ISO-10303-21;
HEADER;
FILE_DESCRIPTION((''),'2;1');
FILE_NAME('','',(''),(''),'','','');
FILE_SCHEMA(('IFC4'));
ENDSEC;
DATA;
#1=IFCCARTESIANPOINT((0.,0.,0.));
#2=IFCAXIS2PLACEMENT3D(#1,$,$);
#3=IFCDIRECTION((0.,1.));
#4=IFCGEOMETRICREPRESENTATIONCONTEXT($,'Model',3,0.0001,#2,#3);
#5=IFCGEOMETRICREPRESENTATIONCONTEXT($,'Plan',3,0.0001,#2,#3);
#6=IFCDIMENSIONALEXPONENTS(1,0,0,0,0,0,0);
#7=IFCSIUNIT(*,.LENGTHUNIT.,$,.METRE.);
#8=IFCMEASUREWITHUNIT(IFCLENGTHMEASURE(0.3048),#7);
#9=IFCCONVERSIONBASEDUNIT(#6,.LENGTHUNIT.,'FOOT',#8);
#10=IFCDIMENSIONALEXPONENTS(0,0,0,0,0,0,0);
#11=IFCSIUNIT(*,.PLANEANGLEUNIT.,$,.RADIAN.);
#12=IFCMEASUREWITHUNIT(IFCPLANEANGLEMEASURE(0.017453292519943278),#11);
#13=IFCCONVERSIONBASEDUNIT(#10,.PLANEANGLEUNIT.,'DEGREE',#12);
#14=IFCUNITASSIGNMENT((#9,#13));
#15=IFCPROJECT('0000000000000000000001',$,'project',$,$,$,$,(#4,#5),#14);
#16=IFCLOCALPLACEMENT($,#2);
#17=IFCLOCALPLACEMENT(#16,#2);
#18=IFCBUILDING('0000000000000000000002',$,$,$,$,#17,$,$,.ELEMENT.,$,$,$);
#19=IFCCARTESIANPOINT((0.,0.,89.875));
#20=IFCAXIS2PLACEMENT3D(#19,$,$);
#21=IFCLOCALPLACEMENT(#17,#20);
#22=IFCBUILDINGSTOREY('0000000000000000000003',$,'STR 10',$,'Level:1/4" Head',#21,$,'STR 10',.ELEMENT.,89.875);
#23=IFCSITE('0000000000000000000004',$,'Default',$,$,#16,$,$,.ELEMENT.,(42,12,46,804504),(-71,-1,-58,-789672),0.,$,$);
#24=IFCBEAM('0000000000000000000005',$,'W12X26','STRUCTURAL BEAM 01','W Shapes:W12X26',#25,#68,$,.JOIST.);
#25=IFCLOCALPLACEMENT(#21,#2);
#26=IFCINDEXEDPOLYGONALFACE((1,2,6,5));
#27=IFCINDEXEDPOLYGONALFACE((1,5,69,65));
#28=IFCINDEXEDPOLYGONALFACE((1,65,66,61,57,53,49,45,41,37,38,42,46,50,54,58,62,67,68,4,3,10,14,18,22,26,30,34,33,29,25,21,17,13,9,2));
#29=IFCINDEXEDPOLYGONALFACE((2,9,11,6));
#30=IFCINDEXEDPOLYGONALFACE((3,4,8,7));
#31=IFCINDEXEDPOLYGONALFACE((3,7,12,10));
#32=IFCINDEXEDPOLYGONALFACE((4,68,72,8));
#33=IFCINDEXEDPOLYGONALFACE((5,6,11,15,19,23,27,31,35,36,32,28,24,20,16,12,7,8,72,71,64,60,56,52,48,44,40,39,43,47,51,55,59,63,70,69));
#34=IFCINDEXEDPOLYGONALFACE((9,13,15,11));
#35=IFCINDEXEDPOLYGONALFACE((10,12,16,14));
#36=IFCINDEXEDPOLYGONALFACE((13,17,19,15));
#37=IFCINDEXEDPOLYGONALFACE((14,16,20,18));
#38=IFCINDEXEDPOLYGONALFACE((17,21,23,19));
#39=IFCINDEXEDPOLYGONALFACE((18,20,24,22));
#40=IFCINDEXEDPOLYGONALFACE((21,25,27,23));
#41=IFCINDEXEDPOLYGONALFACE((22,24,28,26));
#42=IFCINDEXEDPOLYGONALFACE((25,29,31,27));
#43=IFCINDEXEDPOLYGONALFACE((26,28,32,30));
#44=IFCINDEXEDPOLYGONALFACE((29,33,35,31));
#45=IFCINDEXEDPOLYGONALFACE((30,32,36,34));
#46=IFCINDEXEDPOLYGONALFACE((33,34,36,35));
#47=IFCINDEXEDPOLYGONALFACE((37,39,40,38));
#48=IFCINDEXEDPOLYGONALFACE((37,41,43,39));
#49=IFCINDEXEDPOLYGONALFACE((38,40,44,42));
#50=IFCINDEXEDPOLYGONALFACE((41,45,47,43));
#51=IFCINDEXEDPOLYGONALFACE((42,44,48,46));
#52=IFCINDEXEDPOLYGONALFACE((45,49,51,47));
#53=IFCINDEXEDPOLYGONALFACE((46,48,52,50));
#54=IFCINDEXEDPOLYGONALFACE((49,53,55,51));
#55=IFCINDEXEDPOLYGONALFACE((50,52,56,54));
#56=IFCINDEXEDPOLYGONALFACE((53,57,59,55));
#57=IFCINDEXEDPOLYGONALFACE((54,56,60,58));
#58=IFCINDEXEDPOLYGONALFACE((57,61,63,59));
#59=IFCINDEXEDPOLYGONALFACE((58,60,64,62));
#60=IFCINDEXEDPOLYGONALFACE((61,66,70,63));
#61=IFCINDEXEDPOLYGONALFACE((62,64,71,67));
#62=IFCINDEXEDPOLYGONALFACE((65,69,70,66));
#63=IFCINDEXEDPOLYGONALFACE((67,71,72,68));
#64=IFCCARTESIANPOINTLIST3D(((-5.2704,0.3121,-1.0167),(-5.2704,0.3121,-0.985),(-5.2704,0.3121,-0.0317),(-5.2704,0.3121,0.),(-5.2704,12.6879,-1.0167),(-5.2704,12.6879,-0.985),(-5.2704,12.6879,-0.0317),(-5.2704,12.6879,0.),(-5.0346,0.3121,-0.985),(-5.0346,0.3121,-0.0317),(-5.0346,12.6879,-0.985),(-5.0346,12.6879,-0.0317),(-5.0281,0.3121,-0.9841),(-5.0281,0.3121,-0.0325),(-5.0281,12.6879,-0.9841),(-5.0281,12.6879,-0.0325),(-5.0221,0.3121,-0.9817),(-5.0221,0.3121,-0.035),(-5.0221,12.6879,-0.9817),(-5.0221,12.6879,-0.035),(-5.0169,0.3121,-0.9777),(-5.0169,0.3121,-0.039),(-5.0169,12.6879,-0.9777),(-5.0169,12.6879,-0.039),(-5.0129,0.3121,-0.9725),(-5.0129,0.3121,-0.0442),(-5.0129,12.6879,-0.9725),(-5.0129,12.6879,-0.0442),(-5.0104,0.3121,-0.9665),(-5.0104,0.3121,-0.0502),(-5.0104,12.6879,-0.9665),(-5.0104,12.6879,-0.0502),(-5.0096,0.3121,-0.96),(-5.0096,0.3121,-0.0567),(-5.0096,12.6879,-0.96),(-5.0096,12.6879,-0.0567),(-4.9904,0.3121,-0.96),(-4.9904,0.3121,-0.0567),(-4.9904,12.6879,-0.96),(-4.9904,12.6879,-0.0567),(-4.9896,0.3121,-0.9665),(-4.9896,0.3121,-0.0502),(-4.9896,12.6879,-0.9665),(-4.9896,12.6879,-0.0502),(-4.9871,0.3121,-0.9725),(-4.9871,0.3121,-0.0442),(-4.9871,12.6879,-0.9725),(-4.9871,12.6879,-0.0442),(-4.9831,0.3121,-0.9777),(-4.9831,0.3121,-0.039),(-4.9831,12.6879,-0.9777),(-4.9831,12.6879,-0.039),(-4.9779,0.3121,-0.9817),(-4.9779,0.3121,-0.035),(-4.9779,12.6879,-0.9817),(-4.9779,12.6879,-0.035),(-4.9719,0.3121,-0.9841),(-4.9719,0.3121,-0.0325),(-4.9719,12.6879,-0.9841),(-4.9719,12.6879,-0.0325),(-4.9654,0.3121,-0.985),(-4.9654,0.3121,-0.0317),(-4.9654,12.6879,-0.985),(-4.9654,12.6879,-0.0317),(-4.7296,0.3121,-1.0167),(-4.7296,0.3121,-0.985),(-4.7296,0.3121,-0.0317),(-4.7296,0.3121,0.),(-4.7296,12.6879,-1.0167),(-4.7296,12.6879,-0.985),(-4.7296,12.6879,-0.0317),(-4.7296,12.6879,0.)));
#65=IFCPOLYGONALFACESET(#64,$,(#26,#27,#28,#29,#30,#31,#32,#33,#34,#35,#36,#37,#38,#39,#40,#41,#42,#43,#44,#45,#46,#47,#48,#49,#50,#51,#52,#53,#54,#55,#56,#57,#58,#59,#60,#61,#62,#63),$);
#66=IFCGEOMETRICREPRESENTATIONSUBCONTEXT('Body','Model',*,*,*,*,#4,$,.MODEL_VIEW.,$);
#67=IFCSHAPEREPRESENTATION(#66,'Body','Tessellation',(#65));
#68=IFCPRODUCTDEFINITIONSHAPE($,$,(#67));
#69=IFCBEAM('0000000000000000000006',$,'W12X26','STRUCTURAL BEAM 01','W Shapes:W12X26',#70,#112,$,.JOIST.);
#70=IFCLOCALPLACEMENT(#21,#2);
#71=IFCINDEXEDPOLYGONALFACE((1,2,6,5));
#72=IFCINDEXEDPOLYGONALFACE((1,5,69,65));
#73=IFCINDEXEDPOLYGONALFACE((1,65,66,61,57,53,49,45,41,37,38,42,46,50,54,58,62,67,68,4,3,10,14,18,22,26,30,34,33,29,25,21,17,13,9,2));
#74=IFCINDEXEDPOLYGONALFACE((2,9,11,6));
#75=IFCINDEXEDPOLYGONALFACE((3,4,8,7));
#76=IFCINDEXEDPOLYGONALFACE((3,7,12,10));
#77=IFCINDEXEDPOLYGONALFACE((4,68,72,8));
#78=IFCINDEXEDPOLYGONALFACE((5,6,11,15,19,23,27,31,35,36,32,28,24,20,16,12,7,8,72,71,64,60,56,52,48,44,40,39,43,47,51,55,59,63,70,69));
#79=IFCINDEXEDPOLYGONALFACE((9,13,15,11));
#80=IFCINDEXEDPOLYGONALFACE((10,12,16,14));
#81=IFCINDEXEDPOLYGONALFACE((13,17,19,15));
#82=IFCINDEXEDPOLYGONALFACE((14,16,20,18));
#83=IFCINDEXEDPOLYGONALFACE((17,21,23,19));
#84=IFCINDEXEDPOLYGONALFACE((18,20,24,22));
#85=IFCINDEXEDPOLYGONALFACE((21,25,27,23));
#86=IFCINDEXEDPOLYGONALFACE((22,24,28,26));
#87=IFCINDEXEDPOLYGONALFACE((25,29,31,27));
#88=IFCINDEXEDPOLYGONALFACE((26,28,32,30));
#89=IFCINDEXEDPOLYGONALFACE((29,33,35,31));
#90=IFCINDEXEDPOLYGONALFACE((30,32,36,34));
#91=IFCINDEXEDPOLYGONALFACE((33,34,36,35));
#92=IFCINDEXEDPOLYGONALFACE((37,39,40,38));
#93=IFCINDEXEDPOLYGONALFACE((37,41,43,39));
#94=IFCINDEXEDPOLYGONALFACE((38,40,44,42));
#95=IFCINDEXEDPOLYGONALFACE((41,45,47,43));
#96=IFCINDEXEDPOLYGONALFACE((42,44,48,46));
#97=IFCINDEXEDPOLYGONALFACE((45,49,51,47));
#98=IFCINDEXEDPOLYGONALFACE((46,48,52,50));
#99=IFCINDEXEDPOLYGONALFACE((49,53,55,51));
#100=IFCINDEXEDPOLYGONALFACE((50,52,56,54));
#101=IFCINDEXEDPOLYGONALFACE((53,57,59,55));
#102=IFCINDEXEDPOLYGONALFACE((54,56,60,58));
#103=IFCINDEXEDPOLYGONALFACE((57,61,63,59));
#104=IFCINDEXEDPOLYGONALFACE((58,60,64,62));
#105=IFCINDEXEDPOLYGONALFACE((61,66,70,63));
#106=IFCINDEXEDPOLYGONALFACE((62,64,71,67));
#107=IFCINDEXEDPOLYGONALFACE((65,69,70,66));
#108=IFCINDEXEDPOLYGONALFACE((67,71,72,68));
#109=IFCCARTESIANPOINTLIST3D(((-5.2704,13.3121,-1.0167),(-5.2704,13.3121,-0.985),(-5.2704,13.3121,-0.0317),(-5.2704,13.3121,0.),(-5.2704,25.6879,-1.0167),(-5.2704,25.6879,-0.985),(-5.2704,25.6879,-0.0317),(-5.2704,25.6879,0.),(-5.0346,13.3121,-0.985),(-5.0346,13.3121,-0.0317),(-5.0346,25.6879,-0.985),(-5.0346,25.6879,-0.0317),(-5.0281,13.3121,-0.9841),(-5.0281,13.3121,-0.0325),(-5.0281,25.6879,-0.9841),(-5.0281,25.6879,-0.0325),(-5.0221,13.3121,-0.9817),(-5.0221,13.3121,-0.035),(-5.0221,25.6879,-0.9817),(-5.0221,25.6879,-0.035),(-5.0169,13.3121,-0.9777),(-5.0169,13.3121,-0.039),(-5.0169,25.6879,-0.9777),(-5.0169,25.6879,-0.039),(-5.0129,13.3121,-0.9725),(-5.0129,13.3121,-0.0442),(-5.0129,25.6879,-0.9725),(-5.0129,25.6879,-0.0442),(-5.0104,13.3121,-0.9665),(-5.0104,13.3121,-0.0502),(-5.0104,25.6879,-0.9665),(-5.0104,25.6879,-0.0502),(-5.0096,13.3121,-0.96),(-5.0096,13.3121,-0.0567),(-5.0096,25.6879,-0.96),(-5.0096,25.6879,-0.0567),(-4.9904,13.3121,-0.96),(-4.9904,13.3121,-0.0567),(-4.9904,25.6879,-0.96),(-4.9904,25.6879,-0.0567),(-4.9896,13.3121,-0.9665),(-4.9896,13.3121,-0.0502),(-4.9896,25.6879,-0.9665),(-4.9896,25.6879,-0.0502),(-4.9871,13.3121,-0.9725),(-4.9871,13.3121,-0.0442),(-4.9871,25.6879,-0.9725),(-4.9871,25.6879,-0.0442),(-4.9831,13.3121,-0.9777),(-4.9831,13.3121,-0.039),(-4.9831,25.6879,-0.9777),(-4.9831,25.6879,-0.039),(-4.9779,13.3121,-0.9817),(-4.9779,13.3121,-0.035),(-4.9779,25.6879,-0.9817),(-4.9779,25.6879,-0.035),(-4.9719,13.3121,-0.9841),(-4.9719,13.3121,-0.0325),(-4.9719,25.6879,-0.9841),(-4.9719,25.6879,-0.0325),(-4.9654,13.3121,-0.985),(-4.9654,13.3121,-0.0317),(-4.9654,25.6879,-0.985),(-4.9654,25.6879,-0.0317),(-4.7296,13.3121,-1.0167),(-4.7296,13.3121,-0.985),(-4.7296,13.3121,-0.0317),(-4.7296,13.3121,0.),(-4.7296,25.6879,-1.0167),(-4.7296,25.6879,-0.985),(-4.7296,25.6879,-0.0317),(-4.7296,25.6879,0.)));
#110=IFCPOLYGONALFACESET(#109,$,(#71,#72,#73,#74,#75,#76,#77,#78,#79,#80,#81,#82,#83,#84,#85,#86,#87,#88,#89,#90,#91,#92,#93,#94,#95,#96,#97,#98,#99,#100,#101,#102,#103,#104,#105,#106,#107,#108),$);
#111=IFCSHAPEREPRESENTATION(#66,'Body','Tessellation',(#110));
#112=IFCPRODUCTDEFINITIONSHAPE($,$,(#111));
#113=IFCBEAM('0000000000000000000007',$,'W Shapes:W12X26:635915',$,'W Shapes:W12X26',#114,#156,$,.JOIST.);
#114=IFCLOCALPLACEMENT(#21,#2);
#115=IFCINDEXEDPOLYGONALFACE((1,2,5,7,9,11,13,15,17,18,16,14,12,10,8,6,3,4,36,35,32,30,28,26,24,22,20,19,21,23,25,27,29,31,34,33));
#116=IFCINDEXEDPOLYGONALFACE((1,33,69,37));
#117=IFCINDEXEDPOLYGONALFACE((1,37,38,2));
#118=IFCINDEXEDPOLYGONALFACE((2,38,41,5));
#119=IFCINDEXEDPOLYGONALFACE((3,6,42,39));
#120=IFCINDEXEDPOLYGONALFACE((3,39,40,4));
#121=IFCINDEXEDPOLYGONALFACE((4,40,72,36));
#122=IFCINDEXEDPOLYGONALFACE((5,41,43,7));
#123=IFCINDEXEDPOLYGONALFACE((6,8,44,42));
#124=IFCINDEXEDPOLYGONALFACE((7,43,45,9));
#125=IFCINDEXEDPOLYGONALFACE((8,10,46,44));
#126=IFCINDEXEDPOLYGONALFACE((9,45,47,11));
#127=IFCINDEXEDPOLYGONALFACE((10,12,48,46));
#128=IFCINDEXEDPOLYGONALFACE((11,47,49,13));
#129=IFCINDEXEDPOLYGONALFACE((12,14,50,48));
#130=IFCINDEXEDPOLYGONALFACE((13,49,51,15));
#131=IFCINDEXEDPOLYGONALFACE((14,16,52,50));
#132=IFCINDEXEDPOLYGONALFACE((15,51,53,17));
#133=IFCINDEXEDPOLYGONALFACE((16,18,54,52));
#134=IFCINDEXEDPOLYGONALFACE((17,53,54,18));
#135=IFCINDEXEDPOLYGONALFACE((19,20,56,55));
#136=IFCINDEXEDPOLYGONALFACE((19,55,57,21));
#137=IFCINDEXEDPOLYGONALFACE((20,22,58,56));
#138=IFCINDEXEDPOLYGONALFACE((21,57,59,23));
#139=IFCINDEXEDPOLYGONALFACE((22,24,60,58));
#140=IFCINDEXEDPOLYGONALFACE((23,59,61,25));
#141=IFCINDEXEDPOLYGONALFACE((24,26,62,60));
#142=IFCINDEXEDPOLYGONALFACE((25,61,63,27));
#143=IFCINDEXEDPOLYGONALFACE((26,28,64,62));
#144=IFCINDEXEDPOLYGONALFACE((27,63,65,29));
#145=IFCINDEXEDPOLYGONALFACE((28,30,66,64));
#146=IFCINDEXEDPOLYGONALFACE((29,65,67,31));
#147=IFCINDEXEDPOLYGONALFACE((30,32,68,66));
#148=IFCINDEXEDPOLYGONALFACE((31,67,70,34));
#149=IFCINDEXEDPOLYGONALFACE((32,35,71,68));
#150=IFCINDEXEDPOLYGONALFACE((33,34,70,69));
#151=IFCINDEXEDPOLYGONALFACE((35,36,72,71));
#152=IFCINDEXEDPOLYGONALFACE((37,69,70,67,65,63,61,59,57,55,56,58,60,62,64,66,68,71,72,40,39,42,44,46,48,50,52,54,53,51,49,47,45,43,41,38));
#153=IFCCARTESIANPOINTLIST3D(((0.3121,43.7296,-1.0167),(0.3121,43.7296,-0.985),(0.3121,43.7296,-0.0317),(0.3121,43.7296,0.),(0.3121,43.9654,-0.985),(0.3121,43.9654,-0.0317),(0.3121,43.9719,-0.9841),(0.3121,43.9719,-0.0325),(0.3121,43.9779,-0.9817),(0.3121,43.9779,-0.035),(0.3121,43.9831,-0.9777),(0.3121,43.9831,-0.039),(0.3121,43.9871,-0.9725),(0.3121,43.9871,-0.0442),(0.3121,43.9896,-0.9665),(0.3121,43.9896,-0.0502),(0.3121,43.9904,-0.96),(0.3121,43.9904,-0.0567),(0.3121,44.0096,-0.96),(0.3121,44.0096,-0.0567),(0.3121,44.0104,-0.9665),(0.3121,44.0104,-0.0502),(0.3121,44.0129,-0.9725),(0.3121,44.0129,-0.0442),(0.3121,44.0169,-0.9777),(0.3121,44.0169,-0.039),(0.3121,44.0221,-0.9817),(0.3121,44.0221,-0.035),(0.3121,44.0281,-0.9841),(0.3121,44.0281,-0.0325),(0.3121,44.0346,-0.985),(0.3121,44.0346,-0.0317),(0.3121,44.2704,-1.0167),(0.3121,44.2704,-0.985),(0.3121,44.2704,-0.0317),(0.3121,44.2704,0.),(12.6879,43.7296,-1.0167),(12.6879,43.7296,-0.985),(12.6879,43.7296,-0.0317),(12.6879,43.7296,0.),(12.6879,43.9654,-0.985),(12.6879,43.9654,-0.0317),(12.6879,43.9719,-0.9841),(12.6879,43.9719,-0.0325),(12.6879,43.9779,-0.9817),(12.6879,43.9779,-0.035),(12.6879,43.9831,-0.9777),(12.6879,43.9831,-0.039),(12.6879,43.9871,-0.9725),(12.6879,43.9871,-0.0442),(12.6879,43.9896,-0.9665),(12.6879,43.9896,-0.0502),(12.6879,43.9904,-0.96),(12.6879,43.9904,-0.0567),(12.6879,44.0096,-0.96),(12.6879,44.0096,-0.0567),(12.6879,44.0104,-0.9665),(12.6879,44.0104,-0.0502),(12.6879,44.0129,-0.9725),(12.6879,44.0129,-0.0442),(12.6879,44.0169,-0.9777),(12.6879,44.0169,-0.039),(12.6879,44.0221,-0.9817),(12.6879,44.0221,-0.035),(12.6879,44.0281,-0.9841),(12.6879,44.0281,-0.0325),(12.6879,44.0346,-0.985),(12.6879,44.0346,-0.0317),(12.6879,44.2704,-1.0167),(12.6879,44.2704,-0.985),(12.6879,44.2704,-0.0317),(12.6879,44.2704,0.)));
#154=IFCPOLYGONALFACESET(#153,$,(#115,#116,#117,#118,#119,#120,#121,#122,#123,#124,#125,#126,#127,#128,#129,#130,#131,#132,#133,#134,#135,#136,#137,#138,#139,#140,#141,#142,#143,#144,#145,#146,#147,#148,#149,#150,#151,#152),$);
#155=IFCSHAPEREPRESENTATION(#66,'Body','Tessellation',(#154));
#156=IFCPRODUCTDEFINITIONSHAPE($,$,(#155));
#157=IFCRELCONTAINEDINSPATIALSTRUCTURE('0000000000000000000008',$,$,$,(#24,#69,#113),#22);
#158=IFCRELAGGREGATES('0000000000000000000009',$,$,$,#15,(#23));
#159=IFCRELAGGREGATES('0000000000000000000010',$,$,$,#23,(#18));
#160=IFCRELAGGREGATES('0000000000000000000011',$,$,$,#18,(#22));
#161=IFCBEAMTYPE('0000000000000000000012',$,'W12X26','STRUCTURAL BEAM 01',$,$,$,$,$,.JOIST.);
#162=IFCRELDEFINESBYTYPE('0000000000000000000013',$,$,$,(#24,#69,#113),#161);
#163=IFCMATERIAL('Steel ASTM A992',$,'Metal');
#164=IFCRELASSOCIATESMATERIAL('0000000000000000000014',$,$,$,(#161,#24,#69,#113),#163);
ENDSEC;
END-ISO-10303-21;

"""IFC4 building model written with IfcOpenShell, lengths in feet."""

from ifc_helpers import new_model, entity, si_unit, converted_unit, direction, frame, origin, place, context, subcontext, project, spatial, line, arc, indexed_curve, outline, extrude, source, transform, mapped, material, type_object, type_shapes, element, save


model = new_model("IFC4")

# Units and contexts
model_context = context("Model", 3, precision=0.0001, world=origin(), true_north=direction((0.0, 1.0)))
plan_context = context("Plan", 3, precision=0.0001, world=origin(), true_north=direction((0.0, 1.0)))
body_context = subcontext(model_context, "Body", "Model", "MODEL_VIEW")
ifc_project = project(units=[converted_unit("LENGTHUNIT", "FOOT", entity("IfcLengthMeasure", 0.3048), si_unit("LENGTHUNIT", "METRE"), dimensions=[1, 0, 0, 0, 0, 0, 0]), converted_unit("PLANEANGLEUNIT", "DEGREE", entity("IfcPlaneAngleMeasure", 0.017453292519943278), si_unit("PLANEANGLEUNIT", "RADIAN"), dimensions=[0, 0, 0, 0, 0, 0, 0])], contexts=[model_context, plan_context])

# Site, building, storey
site_placement = place(None, origin())
site = spatial("IfcSite", under=ifc_project, at=site_placement, Name="Default", CompositionType="ELEMENT", RefLatitude=(42, 12, 46, 804504), RefLongitude=(-71, -1, -58, -789672), RefElevation=0.0)
building_placement = place(site_placement, origin())
building = spatial("IfcBuilding", under=site, at=building_placement, CompositionType="ELEMENT")
storey_placement = place(building_placement, frame((0.0, 0.0, 89.875)))
storey = spatial("IfcBuildingStorey", under=building, at=storey_placement, Name="STR 10", ObjectType="Level:1/4\" Head", LongName="STR 10", CompositionType="ELEMENT", Elevation=89.875)

# Beams
ifc_material = material(Name="Steel ASTM A992", Category="Metal")
beam_type_1 = type_object("IfcBeamType", Name="W12X26", Description="STRUCTURAL BEAM 01", PredefinedType="JOIST", material=ifc_material)
shared_shape_1 = source(origin(), body_context, "Body", "SweptSolid", [
    extrude(outline(indexed_curve([(-0.2704, -0.4767), (-0.2704, -0.5083), (0.2704, -0.5083), (0.2704, -0.4767), (0.0346, -0.4767), (0.0169, -0.4693), (0.0096, -0.4517), (0.0096, 0.4517), (0.0169, 0.4693), (0.0346, 0.4767), (0.2704, 0.4767), (0.2704, 0.5083), (-0.2704, 0.5083), (-0.2704, 0.4767), (-0.0346, 0.4767), (-0.0169, 0.4693), (-0.0096, 0.4517), (-0.0096, -0.4517), (-0.0169, -0.4693), (-0.0346, -0.4767)], segments=[line(1, 2, 3, 4, 5), arc(5, 6, 7), line(7, 8), arc(8, 9, 10), line(10, 11, 12, 13, 14, 15), arc(15, 16, 17), line(17, 18), arc(18, 19, 20), line(20, 1)], self_intersect=False)), frame((-6.1879, 0.0, 0.0), z_axis=(-1.0, 0.0, 0.0), x_axis=(0.0, -1.0, 0.0)), (0.0, 0.0, -1.0), 12.3758),
])
type_shapes(beam_type_1, [shared_shape_1])
for number, where, z_axis, x_axis, name in (
    (1, (-5.0, 6.5, -0.5083), (0.0, 0.0, 1.0), (0.0, -1.0, 0.0), "W12X26"),
    (2, (-5.0, 19.5, -0.5083), (0.0, 0.0, 1.0), (0.0, 1.0, 0.0), "W12X26"),
):
    element("IfcBeam", number, at=place(storey_placement, frame(where, z_axis=z_axis, x_axis=x_axis)), inside=storey, type_object=beam_type_1, material=ifc_material, Name=name, Description="STRUCTURAL BEAM 01", ObjectType="W Shapes:W12X26", PredefinedType="JOIST", context=body_context, shape_type="MappedRepresentation", body=[
        mapped(shared_shape_1, transform((0.0, 0.0, 0.0), scale=1.0)),
    ])
beam_1_placement = place(storey_placement, frame((6.5, 44.0, -0.5083)))
element("IfcBeam", 3, at=beam_1_placement, inside=storey, type_object=beam_type_1, material=ifc_material, Name="W Shapes:W12X26:635915", ObjectType="W Shapes:W12X26", PredefinedType="JOIST", context=body_context, shape_type="MappedRepresentation", body=[
    mapped(shared_shape_1, transform((0.0, 0.0, 0.0), scale=1.0)),
])

save(model, "model.ifc")
